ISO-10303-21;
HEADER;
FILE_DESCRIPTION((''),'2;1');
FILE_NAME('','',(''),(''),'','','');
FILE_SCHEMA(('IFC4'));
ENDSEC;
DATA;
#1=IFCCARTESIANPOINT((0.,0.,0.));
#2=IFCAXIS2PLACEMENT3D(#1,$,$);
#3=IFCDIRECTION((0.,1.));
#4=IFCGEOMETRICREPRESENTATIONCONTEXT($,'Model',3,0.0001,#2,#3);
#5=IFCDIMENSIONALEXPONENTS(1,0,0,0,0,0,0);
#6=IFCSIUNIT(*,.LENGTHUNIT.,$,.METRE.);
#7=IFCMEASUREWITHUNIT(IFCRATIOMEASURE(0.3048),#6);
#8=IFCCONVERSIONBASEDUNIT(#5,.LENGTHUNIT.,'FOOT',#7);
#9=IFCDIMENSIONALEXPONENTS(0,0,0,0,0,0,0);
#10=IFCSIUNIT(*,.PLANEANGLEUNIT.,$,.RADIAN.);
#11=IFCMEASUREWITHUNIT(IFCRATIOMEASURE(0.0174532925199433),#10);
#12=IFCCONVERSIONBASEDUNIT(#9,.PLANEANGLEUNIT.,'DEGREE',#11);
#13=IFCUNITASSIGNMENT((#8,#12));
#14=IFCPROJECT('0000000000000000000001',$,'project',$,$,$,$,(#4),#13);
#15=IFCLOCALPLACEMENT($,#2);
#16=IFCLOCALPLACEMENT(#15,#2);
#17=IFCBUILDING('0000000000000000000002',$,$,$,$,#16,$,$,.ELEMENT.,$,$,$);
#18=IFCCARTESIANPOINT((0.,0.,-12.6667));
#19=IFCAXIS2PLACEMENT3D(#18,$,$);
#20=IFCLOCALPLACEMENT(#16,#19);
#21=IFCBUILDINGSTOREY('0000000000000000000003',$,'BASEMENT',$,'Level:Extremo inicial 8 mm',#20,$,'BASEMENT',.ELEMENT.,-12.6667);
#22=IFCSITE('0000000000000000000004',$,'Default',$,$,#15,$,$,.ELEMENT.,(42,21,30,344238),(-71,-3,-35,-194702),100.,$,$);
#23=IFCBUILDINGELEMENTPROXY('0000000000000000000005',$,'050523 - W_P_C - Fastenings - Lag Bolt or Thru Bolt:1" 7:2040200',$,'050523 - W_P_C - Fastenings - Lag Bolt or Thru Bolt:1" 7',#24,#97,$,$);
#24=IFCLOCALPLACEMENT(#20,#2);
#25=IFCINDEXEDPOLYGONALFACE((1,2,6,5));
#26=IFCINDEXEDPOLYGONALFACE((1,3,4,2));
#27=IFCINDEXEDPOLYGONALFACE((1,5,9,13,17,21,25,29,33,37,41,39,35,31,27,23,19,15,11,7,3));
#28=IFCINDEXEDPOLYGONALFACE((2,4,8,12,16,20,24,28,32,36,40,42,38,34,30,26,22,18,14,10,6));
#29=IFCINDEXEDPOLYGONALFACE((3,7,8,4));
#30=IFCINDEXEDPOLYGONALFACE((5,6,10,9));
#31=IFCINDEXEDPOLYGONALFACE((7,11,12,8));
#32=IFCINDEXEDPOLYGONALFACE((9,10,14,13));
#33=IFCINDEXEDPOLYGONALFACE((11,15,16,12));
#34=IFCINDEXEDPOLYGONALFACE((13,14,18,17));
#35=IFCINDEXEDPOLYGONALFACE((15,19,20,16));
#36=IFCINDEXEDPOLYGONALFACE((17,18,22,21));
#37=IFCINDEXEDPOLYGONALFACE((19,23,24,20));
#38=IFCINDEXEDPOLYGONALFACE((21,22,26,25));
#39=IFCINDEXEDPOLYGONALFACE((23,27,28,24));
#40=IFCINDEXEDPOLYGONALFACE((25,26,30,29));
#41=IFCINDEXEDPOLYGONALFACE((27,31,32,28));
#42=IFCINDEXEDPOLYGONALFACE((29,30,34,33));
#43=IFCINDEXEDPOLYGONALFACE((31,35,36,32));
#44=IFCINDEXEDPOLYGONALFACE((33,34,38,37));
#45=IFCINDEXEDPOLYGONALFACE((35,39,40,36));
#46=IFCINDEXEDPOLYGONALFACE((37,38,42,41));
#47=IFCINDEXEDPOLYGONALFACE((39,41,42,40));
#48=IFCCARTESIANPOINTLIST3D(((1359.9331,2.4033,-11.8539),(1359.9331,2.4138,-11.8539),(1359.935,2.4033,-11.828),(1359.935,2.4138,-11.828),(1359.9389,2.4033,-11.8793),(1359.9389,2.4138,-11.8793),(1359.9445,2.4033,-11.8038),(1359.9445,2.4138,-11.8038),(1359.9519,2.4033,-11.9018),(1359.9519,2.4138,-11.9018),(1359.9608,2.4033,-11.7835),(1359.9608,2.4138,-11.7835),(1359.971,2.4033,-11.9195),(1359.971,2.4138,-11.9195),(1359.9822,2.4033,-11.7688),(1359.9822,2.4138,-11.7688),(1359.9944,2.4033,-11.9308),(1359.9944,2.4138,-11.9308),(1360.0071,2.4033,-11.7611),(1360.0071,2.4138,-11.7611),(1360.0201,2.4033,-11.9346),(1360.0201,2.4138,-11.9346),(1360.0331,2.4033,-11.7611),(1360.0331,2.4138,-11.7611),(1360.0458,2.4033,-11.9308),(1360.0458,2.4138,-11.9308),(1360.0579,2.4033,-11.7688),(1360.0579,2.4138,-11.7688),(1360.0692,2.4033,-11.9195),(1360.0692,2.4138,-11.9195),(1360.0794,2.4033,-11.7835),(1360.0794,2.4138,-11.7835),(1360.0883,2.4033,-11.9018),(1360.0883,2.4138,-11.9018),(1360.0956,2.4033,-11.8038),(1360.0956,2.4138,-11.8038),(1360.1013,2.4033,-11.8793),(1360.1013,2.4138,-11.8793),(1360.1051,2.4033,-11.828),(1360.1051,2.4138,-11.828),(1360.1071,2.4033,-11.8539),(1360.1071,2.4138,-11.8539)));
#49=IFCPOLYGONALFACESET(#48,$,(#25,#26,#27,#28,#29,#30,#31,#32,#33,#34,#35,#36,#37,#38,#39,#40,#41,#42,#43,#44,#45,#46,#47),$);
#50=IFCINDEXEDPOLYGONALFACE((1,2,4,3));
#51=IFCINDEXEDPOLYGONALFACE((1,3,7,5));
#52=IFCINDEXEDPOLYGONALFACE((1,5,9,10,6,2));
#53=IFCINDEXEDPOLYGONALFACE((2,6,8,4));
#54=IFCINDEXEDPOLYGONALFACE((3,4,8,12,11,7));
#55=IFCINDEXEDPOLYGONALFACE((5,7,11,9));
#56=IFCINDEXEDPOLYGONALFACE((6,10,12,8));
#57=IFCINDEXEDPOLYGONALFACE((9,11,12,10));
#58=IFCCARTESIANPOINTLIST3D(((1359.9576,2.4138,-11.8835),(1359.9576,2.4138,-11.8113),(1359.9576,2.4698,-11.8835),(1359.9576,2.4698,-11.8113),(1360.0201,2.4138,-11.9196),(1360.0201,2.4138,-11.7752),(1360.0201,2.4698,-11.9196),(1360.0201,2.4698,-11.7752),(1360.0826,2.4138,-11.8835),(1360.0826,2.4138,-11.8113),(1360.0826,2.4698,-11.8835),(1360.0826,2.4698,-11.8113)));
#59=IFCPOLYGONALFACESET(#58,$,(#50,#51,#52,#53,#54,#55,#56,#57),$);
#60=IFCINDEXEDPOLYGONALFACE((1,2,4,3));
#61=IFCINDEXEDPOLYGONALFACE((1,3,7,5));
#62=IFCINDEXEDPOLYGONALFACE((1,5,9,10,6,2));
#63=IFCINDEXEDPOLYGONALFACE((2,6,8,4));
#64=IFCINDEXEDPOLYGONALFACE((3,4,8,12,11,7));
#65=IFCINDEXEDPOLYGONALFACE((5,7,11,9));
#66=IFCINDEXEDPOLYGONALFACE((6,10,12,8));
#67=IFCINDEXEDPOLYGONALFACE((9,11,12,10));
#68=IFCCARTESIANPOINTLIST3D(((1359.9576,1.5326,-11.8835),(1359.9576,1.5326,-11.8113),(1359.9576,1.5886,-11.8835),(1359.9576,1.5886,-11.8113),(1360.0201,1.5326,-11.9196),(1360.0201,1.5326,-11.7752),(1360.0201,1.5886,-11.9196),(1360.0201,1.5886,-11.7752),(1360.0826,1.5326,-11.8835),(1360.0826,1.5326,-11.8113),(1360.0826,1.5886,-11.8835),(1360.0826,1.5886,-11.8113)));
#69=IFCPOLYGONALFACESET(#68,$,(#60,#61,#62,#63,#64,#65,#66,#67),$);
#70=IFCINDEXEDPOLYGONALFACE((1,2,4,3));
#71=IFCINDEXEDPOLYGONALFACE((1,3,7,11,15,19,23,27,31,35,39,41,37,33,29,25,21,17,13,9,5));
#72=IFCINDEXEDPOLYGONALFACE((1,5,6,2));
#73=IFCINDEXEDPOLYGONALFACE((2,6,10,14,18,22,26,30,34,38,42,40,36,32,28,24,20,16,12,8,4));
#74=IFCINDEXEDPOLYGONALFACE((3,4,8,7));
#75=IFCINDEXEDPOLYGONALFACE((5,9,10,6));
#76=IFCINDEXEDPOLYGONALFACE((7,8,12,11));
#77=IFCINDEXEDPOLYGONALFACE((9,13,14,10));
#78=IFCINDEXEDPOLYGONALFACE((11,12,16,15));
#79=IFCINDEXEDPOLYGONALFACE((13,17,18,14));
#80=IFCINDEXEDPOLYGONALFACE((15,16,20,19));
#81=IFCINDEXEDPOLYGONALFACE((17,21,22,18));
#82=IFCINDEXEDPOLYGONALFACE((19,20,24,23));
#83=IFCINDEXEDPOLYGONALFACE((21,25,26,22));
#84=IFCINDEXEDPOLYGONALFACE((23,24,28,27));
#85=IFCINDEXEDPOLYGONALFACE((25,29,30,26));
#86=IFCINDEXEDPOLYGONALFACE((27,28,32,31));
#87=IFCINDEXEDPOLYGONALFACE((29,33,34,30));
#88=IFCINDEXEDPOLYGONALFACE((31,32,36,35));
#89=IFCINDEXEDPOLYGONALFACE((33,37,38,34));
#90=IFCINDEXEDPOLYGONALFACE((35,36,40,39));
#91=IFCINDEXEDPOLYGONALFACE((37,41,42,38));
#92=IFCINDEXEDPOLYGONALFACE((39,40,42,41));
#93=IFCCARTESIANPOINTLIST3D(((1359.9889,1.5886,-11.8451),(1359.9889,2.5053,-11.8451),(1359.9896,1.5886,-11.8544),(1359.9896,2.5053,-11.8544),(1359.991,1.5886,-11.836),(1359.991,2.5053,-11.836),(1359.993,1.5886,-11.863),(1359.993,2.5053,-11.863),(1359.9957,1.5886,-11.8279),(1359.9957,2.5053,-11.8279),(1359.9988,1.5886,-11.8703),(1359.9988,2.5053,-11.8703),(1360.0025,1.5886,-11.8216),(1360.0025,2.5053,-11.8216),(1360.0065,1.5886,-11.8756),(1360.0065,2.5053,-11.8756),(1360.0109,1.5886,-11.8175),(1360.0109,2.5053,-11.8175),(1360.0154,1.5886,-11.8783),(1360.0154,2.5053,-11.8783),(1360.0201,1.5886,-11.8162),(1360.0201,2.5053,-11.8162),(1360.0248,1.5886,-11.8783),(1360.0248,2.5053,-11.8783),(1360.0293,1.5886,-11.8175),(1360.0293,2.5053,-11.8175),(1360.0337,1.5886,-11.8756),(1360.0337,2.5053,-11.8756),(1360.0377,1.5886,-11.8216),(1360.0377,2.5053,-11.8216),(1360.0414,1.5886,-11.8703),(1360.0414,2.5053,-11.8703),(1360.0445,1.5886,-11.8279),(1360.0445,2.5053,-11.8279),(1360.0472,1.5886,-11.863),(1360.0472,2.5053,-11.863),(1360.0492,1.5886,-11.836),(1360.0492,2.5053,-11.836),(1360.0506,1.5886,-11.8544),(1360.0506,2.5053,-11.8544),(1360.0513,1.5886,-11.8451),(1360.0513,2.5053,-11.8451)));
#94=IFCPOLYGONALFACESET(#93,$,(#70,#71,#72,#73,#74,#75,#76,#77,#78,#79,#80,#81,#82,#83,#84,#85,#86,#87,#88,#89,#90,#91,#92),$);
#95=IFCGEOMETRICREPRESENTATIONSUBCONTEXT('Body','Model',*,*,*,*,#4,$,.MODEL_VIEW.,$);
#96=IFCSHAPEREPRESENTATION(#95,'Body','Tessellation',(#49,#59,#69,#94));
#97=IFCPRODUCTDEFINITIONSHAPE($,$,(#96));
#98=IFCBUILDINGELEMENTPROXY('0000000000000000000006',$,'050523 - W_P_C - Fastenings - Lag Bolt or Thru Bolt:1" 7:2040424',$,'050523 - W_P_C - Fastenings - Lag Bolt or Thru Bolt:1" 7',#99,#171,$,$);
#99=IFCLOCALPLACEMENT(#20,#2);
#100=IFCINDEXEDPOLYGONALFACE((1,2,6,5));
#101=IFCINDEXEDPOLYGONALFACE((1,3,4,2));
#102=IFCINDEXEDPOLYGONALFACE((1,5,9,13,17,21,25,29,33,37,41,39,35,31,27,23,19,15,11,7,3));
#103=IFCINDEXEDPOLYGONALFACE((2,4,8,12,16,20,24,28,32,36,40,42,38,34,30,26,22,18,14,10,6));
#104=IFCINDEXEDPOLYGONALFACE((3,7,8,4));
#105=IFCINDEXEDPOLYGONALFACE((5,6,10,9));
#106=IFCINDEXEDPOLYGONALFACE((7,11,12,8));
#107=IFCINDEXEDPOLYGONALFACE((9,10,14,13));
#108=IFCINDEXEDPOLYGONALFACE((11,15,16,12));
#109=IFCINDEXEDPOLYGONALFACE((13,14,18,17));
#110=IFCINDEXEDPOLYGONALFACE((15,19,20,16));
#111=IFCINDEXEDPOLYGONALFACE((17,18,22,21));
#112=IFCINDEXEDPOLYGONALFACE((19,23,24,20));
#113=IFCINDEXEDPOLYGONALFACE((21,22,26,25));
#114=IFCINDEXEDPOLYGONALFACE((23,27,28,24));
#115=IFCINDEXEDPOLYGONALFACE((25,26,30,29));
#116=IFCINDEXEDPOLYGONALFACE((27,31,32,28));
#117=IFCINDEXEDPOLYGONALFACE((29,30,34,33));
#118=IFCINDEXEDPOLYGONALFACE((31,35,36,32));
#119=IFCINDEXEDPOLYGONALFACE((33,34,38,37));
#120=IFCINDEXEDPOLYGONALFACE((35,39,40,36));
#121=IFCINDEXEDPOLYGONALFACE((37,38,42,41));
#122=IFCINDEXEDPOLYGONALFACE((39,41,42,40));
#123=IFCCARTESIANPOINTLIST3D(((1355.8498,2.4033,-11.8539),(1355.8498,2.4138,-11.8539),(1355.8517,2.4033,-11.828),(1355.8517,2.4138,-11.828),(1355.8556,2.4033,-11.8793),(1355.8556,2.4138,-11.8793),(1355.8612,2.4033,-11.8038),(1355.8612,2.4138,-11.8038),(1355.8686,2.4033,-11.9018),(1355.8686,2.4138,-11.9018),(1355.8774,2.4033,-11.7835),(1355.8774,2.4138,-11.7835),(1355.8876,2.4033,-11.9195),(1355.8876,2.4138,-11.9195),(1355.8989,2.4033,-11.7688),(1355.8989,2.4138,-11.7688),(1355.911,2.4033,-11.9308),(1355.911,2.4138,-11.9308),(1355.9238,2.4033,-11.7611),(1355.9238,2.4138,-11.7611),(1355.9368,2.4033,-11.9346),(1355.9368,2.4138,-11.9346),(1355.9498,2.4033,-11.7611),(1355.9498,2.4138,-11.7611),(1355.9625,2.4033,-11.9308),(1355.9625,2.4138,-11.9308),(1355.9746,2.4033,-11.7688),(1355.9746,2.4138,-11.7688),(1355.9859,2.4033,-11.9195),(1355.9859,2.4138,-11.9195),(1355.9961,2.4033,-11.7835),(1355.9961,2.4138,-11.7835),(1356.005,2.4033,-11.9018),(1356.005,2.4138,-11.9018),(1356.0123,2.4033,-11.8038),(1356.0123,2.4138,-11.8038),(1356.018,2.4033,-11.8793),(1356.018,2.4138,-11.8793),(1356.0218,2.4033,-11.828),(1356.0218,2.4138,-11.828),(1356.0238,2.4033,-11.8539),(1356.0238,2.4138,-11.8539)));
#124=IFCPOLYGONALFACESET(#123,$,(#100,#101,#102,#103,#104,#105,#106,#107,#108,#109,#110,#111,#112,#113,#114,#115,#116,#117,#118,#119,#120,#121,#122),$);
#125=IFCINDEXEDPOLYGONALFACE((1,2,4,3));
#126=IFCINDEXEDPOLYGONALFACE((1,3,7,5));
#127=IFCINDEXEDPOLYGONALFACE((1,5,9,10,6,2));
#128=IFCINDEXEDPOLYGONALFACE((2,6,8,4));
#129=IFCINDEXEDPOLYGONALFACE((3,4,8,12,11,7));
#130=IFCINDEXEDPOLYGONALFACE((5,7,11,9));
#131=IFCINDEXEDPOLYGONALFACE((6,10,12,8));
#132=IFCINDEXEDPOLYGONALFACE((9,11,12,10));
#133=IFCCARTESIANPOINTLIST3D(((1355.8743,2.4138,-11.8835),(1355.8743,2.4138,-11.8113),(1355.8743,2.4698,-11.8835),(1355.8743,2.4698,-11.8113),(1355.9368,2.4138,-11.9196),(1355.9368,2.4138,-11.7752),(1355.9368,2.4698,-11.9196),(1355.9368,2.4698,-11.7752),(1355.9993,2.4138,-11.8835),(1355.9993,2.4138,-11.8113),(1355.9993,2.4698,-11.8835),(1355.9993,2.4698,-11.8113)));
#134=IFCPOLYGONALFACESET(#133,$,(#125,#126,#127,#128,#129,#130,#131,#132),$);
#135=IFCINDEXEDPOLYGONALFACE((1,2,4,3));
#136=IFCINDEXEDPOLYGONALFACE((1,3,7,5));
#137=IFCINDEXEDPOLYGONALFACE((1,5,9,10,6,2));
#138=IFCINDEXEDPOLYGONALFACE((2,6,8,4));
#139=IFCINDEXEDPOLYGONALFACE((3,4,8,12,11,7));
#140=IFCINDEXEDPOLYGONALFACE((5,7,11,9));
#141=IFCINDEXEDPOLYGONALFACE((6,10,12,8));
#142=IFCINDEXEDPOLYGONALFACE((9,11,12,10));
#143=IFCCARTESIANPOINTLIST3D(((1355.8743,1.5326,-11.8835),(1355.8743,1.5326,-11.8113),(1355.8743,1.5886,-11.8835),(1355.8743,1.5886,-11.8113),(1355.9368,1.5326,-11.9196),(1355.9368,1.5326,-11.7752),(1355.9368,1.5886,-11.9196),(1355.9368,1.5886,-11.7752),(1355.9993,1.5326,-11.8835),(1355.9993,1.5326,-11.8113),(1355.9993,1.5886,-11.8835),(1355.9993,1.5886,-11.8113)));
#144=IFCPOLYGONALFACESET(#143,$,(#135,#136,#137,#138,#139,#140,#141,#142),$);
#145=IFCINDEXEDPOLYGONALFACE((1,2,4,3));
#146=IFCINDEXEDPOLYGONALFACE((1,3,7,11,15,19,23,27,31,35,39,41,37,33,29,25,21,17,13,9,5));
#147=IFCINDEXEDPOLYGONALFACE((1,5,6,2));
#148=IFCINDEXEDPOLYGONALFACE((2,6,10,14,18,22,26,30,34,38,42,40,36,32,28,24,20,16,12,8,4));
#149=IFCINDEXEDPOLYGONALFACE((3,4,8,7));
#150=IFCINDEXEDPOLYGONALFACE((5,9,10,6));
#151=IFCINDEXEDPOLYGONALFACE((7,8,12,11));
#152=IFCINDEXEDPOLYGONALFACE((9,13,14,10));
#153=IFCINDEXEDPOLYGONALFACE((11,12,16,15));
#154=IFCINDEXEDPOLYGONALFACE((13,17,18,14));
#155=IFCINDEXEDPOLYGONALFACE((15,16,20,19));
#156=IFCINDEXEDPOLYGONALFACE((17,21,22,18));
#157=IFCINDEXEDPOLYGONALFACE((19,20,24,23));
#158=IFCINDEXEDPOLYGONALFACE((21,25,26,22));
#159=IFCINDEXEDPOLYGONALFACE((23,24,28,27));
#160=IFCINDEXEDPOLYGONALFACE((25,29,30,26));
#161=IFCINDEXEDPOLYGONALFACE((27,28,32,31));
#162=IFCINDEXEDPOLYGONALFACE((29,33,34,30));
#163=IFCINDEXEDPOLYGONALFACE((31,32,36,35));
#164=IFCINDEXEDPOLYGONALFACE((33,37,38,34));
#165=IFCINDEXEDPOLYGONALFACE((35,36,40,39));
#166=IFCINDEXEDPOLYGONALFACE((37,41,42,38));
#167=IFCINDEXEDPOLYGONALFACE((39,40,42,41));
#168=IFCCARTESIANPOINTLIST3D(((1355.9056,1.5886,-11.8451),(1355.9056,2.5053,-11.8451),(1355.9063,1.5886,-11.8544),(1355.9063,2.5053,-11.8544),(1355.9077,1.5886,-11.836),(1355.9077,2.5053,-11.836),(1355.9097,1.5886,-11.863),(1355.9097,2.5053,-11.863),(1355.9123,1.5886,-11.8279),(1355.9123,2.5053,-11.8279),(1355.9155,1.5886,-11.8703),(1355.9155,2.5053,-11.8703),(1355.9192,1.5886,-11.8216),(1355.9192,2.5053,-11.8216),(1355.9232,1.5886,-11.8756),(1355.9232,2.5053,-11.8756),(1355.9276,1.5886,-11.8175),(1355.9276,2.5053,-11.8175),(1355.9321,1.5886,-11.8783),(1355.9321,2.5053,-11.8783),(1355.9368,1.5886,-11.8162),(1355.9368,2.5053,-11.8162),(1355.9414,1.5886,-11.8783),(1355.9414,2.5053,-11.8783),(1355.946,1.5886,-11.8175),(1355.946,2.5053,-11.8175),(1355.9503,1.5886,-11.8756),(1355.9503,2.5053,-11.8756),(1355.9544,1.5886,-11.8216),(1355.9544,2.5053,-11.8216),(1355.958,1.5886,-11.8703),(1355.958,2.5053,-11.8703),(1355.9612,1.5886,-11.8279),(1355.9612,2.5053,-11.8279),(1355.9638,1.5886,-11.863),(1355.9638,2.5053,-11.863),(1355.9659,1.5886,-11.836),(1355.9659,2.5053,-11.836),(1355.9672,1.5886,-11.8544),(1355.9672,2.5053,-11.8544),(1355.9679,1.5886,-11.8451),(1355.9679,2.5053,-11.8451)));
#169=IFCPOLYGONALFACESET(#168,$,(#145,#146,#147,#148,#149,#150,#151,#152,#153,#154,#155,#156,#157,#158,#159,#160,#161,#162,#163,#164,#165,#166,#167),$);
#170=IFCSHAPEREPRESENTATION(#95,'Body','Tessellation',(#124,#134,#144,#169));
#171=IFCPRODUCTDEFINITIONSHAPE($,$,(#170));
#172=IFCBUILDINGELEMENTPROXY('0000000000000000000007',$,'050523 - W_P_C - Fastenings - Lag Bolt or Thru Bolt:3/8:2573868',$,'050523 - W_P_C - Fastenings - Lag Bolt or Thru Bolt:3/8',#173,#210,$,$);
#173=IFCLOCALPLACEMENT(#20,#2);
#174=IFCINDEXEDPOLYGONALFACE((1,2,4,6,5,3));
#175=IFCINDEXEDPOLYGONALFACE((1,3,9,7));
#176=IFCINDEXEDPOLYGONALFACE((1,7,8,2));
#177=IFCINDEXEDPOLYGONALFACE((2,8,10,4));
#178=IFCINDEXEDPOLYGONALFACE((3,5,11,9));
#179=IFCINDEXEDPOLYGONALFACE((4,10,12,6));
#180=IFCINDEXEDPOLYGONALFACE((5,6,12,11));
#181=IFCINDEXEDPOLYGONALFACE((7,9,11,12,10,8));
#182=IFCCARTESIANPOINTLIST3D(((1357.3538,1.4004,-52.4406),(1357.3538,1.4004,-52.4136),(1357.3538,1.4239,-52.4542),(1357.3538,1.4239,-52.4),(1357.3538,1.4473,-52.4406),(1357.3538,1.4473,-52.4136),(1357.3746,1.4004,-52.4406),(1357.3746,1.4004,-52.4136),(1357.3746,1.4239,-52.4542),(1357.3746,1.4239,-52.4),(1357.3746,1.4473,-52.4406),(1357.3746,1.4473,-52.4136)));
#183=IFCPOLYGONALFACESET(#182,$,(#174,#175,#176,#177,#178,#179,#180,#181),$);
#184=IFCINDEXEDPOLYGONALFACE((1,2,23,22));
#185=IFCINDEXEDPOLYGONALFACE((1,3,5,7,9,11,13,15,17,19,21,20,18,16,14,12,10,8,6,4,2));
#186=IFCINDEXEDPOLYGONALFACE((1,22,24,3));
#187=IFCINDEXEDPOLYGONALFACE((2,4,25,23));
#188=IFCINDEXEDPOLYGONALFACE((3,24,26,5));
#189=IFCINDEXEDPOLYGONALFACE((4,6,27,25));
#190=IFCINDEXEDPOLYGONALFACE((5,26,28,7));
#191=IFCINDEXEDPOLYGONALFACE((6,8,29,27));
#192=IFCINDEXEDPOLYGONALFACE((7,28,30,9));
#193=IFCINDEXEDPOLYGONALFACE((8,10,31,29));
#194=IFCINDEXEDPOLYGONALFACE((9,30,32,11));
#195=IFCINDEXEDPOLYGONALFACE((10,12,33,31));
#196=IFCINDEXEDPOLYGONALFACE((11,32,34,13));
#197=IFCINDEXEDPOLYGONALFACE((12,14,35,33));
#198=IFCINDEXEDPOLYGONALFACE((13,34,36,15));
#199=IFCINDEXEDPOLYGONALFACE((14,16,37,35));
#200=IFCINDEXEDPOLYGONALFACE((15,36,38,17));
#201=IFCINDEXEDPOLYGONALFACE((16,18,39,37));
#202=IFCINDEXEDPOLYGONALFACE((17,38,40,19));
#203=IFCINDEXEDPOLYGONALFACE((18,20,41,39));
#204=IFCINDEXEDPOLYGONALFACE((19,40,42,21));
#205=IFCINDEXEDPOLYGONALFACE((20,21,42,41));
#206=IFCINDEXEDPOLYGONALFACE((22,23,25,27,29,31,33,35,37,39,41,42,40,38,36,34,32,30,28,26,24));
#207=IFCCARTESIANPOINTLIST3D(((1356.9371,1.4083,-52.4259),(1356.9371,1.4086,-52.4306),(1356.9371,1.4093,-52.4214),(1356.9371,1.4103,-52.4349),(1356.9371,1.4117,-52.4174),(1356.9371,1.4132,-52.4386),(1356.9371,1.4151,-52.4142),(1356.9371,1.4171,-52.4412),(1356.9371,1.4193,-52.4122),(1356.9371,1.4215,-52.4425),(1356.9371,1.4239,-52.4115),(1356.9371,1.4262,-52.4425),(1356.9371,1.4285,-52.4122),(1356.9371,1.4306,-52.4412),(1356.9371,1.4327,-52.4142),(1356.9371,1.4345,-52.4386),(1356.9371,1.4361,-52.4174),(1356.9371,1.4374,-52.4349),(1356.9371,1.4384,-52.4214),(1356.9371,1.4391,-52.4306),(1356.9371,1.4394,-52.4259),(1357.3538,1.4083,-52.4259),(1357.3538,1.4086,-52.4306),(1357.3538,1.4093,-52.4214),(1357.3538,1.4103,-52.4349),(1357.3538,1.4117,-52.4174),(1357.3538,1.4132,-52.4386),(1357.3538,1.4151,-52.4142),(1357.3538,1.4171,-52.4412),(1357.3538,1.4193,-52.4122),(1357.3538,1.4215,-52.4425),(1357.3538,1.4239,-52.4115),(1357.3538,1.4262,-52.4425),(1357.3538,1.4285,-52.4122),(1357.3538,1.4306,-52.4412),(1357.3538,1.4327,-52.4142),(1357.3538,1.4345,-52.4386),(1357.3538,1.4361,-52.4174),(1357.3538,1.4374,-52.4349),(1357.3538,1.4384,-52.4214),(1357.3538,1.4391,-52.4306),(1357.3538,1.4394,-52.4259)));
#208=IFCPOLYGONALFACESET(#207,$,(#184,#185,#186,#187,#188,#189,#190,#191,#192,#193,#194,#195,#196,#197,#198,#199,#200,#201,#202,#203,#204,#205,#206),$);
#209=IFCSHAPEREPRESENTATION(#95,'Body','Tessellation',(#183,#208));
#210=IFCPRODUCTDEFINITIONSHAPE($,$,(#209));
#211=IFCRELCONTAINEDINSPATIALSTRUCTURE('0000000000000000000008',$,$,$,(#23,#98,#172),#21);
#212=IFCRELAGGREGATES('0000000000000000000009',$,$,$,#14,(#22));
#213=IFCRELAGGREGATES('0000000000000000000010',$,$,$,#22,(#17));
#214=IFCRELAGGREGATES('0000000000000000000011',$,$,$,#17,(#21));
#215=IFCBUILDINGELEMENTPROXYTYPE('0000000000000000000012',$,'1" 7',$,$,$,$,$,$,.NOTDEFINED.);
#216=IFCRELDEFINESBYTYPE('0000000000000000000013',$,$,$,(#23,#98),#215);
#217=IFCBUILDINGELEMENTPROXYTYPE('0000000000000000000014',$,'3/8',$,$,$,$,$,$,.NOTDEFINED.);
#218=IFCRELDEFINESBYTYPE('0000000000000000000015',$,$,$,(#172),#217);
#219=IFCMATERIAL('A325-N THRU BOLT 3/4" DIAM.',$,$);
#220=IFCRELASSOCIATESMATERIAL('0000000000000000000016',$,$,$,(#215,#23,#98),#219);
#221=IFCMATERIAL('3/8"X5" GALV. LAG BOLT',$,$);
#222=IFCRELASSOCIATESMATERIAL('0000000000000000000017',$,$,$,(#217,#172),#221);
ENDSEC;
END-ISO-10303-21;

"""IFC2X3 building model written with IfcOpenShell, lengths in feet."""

from ifc_helpers import new_model, entity, si_unit, converted_unit, direction, frame, frame_2d, origin, place, context, subcontext, project, spatial, polyline, circle, outline, extrude, source, transform, mapped, material, type_object, type_shapes, element, save


model = new_model("IFC2X3")

# Units and contexts
model_context = context("Model", 3, precision=0.0001, world=origin(), true_north=direction((0.0, 1.0)))
body_context = subcontext(model_context, "Body", "Model", "MODEL_VIEW")
ifc_project = project(units=[converted_unit("LENGTHUNIT", "FOOT", entity("IfcRatioMeasure", 0.3048), si_unit("LENGTHUNIT", "METRE"), dimensions=[1, 0, 0, 0, 0, 0, 0]), converted_unit("PLANEANGLEUNIT", "DEGREE", entity("IfcRatioMeasure", 0.0174532925199433), si_unit("PLANEANGLEUNIT", "RADIAN"), dimensions=[0, 0, 0, 0, 0, 0, 0])], contexts=[model_context])

# Site, building, storey
site_placement = place(None, origin())
site = spatial("IfcSite", under=ifc_project, at=site_placement, Name="Default", CompositionType="ELEMENT", RefLatitude=(42, 21, 30, 344238), RefLongitude=(-71, -3, -35, -194702), RefElevation=100.0)
building_placement = place(site_placement, origin())
building = spatial("IfcBuilding", under=site, at=building_placement, CompositionType="ELEMENT")
storey_placement = place(building_placement, frame((0.0, 0.0, -12.6667)))
storey = spatial("IfcBuildingStorey", under=building, at=storey_placement, Name="BASEMENT", ObjectType="Level:Extremo inicial 8 mm", LongName="BASEMENT", CompositionType="ELEMENT", Elevation=-12.6667)

# Building element proxies
ifc_material_1 = material(Name="A325-N THRU BOLT 3/4\" DIAM.")
building_element_proxy_type_1 = type_object("IfcBuildingElementProxyType", Name="1\" 7", PredefinedType="NOTDEFINED", material=ifc_material_1)
shared_shape_1 = source(origin(), body_context, "Body", "SweptSolid", [
    extrude(circle(Radius=0.0872, at=frame_2d((0.0, 0.0), x_axis=(1.0, 0.0))), frame((0.0, 0.0, -0.8251), z_axis=(0.0, 0.0, 1.0), x_axis=(0.0, -1.0, 0.0)), (0.0, 0.0, 1.0), 0.0104),
    extrude(outline(polyline([(-0.0361, -0.0625), (0.0361, -0.0625), (0.0722, 0.0), (0.0361, 0.0625), (-0.0361, 0.0625), (-0.0722, 0.0), (-0.0361, -0.0625)])), frame((0.0, 0.0, -0.8811), z_axis=(0.0, 0.0, 1.0), x_axis=(0.866025, -0.5, 0.0)), (0.0, 0.0, 1.0), 0.056),
    extrude(outline(polyline([(-0.0361, -0.0625), (0.0361, -0.0625), (0.0722, 0.0), (0.0361, 0.0625), (-0.0361, 0.0625), (-0.0722, 0.0), (-0.0361, -0.0625)])), frame((0.0, 0.0, 0.0), z_axis=(0.0, 0.0, 1.0), x_axis=(0.0, -1.0, 0.0)), (0.0, 0.0, 1.0), 0.056),
    extrude(circle(Radius=0.0312, at=frame_2d((0.0, 0.0), x_axis=(1.0, 0.0))), frame((0.0, 0.0, -0.9167), z_axis=(0.0, 0.0, 1.0), x_axis=(0.0, 1.0, 0.0)), (0.0, 0.0, 1.0), 0.9167),
])
type_shapes(building_element_proxy_type_1, [shared_shape_1])
for number, where, z_axis, x_axis, name in (
    (1, (1360.0201, 1.5886, -11.8474), (0.0, -1.0, 0.0), (1.0, 0.0, 0.0), "050523 - W_P_C - Fastenings - Lag Bolt or Thru Bolt:1\" 7:2040200"),
    (2, (1355.9368, 1.5886, -11.8474), (0.0, -1.0, 0.0), (1.0, 0.0, 0.0), "050523 - W_P_C - Fastenings - Lag Bolt or Thru Bolt:1\" 7:2040424"),
):
    element("IfcBuildingElementProxy", number, at=place(storey_placement, frame(where, z_axis=z_axis, x_axis=x_axis)), inside=storey, type_object=building_element_proxy_type_1, material=ifc_material_1, Name=name, ObjectType="050523 - W_P_C - Fastenings - Lag Bolt or Thru Bolt:1\" 7", context=body_context, shape_type="MappedRepresentation", body=[
        mapped(shared_shape_1, transform((0.0, 0.0, 0.0), scale=1.0)),
    ])
ifc_material_2 = material(Name="3/8\"X5\" GALV. LAG BOLT")
building_element_proxy_type_2 = type_object("IfcBuildingElementProxyType", Name="3/8", PredefinedType="NOTDEFINED", material=ifc_material_2)
shared_shape_2 = source(origin(), body_context, "Body", "SweptSolid", [
    extrude(outline(polyline([(-0.0135, -0.0234), (0.0135, -0.0234), (0.0271, 0.0), (0.0135, 0.0234), (-0.0135, 0.0234), (-0.0271, 0.0), (-0.0135, -0.0234)])), frame((0.0, 0.0, 0.0), z_axis=(0.0, 0.0, 1.0), x_axis=(0.0, -1.0, 0.0)), (0.0, 0.0, 1.0), 0.0208),
    extrude(circle(Radius=0.0156, at=frame_2d((0.0, 0.0), x_axis=(1.0, 0.0))), frame((0.0, 0.0, -0.4167), z_axis=(0.0, 0.0, 1.0), x_axis=(0.0, 1.0, 0.0)), (0.0, 0.0, 1.0), 0.4167),
])
type_shapes(building_element_proxy_type_2, [shared_shape_2])
for number, where, z_axis, x_axis, name in (
    (3, (1357.3538, 1.4239, -52.4271), (1.0, 0.0, 0.0), (0.0, 1.0, 0.0), "050523 - W_P_C - Fastenings - Lag Bolt or Thru Bolt:3/8:2573868"),
):
    element("IfcBuildingElementProxy", number, at=place(storey_placement, frame(where, z_axis=z_axis, x_axis=x_axis)), inside=storey, type_object=building_element_proxy_type_2, material=ifc_material_2, Name=name, ObjectType="050523 - W_P_C - Fastenings - Lag Bolt or Thru Bolt:3/8", context=body_context, shape_type="MappedRepresentation", body=[
        mapped(shared_shape_2, transform((0.0, 0.0, 0.0), scale=1.0)),
    ])

save(model, "model.ifc")
